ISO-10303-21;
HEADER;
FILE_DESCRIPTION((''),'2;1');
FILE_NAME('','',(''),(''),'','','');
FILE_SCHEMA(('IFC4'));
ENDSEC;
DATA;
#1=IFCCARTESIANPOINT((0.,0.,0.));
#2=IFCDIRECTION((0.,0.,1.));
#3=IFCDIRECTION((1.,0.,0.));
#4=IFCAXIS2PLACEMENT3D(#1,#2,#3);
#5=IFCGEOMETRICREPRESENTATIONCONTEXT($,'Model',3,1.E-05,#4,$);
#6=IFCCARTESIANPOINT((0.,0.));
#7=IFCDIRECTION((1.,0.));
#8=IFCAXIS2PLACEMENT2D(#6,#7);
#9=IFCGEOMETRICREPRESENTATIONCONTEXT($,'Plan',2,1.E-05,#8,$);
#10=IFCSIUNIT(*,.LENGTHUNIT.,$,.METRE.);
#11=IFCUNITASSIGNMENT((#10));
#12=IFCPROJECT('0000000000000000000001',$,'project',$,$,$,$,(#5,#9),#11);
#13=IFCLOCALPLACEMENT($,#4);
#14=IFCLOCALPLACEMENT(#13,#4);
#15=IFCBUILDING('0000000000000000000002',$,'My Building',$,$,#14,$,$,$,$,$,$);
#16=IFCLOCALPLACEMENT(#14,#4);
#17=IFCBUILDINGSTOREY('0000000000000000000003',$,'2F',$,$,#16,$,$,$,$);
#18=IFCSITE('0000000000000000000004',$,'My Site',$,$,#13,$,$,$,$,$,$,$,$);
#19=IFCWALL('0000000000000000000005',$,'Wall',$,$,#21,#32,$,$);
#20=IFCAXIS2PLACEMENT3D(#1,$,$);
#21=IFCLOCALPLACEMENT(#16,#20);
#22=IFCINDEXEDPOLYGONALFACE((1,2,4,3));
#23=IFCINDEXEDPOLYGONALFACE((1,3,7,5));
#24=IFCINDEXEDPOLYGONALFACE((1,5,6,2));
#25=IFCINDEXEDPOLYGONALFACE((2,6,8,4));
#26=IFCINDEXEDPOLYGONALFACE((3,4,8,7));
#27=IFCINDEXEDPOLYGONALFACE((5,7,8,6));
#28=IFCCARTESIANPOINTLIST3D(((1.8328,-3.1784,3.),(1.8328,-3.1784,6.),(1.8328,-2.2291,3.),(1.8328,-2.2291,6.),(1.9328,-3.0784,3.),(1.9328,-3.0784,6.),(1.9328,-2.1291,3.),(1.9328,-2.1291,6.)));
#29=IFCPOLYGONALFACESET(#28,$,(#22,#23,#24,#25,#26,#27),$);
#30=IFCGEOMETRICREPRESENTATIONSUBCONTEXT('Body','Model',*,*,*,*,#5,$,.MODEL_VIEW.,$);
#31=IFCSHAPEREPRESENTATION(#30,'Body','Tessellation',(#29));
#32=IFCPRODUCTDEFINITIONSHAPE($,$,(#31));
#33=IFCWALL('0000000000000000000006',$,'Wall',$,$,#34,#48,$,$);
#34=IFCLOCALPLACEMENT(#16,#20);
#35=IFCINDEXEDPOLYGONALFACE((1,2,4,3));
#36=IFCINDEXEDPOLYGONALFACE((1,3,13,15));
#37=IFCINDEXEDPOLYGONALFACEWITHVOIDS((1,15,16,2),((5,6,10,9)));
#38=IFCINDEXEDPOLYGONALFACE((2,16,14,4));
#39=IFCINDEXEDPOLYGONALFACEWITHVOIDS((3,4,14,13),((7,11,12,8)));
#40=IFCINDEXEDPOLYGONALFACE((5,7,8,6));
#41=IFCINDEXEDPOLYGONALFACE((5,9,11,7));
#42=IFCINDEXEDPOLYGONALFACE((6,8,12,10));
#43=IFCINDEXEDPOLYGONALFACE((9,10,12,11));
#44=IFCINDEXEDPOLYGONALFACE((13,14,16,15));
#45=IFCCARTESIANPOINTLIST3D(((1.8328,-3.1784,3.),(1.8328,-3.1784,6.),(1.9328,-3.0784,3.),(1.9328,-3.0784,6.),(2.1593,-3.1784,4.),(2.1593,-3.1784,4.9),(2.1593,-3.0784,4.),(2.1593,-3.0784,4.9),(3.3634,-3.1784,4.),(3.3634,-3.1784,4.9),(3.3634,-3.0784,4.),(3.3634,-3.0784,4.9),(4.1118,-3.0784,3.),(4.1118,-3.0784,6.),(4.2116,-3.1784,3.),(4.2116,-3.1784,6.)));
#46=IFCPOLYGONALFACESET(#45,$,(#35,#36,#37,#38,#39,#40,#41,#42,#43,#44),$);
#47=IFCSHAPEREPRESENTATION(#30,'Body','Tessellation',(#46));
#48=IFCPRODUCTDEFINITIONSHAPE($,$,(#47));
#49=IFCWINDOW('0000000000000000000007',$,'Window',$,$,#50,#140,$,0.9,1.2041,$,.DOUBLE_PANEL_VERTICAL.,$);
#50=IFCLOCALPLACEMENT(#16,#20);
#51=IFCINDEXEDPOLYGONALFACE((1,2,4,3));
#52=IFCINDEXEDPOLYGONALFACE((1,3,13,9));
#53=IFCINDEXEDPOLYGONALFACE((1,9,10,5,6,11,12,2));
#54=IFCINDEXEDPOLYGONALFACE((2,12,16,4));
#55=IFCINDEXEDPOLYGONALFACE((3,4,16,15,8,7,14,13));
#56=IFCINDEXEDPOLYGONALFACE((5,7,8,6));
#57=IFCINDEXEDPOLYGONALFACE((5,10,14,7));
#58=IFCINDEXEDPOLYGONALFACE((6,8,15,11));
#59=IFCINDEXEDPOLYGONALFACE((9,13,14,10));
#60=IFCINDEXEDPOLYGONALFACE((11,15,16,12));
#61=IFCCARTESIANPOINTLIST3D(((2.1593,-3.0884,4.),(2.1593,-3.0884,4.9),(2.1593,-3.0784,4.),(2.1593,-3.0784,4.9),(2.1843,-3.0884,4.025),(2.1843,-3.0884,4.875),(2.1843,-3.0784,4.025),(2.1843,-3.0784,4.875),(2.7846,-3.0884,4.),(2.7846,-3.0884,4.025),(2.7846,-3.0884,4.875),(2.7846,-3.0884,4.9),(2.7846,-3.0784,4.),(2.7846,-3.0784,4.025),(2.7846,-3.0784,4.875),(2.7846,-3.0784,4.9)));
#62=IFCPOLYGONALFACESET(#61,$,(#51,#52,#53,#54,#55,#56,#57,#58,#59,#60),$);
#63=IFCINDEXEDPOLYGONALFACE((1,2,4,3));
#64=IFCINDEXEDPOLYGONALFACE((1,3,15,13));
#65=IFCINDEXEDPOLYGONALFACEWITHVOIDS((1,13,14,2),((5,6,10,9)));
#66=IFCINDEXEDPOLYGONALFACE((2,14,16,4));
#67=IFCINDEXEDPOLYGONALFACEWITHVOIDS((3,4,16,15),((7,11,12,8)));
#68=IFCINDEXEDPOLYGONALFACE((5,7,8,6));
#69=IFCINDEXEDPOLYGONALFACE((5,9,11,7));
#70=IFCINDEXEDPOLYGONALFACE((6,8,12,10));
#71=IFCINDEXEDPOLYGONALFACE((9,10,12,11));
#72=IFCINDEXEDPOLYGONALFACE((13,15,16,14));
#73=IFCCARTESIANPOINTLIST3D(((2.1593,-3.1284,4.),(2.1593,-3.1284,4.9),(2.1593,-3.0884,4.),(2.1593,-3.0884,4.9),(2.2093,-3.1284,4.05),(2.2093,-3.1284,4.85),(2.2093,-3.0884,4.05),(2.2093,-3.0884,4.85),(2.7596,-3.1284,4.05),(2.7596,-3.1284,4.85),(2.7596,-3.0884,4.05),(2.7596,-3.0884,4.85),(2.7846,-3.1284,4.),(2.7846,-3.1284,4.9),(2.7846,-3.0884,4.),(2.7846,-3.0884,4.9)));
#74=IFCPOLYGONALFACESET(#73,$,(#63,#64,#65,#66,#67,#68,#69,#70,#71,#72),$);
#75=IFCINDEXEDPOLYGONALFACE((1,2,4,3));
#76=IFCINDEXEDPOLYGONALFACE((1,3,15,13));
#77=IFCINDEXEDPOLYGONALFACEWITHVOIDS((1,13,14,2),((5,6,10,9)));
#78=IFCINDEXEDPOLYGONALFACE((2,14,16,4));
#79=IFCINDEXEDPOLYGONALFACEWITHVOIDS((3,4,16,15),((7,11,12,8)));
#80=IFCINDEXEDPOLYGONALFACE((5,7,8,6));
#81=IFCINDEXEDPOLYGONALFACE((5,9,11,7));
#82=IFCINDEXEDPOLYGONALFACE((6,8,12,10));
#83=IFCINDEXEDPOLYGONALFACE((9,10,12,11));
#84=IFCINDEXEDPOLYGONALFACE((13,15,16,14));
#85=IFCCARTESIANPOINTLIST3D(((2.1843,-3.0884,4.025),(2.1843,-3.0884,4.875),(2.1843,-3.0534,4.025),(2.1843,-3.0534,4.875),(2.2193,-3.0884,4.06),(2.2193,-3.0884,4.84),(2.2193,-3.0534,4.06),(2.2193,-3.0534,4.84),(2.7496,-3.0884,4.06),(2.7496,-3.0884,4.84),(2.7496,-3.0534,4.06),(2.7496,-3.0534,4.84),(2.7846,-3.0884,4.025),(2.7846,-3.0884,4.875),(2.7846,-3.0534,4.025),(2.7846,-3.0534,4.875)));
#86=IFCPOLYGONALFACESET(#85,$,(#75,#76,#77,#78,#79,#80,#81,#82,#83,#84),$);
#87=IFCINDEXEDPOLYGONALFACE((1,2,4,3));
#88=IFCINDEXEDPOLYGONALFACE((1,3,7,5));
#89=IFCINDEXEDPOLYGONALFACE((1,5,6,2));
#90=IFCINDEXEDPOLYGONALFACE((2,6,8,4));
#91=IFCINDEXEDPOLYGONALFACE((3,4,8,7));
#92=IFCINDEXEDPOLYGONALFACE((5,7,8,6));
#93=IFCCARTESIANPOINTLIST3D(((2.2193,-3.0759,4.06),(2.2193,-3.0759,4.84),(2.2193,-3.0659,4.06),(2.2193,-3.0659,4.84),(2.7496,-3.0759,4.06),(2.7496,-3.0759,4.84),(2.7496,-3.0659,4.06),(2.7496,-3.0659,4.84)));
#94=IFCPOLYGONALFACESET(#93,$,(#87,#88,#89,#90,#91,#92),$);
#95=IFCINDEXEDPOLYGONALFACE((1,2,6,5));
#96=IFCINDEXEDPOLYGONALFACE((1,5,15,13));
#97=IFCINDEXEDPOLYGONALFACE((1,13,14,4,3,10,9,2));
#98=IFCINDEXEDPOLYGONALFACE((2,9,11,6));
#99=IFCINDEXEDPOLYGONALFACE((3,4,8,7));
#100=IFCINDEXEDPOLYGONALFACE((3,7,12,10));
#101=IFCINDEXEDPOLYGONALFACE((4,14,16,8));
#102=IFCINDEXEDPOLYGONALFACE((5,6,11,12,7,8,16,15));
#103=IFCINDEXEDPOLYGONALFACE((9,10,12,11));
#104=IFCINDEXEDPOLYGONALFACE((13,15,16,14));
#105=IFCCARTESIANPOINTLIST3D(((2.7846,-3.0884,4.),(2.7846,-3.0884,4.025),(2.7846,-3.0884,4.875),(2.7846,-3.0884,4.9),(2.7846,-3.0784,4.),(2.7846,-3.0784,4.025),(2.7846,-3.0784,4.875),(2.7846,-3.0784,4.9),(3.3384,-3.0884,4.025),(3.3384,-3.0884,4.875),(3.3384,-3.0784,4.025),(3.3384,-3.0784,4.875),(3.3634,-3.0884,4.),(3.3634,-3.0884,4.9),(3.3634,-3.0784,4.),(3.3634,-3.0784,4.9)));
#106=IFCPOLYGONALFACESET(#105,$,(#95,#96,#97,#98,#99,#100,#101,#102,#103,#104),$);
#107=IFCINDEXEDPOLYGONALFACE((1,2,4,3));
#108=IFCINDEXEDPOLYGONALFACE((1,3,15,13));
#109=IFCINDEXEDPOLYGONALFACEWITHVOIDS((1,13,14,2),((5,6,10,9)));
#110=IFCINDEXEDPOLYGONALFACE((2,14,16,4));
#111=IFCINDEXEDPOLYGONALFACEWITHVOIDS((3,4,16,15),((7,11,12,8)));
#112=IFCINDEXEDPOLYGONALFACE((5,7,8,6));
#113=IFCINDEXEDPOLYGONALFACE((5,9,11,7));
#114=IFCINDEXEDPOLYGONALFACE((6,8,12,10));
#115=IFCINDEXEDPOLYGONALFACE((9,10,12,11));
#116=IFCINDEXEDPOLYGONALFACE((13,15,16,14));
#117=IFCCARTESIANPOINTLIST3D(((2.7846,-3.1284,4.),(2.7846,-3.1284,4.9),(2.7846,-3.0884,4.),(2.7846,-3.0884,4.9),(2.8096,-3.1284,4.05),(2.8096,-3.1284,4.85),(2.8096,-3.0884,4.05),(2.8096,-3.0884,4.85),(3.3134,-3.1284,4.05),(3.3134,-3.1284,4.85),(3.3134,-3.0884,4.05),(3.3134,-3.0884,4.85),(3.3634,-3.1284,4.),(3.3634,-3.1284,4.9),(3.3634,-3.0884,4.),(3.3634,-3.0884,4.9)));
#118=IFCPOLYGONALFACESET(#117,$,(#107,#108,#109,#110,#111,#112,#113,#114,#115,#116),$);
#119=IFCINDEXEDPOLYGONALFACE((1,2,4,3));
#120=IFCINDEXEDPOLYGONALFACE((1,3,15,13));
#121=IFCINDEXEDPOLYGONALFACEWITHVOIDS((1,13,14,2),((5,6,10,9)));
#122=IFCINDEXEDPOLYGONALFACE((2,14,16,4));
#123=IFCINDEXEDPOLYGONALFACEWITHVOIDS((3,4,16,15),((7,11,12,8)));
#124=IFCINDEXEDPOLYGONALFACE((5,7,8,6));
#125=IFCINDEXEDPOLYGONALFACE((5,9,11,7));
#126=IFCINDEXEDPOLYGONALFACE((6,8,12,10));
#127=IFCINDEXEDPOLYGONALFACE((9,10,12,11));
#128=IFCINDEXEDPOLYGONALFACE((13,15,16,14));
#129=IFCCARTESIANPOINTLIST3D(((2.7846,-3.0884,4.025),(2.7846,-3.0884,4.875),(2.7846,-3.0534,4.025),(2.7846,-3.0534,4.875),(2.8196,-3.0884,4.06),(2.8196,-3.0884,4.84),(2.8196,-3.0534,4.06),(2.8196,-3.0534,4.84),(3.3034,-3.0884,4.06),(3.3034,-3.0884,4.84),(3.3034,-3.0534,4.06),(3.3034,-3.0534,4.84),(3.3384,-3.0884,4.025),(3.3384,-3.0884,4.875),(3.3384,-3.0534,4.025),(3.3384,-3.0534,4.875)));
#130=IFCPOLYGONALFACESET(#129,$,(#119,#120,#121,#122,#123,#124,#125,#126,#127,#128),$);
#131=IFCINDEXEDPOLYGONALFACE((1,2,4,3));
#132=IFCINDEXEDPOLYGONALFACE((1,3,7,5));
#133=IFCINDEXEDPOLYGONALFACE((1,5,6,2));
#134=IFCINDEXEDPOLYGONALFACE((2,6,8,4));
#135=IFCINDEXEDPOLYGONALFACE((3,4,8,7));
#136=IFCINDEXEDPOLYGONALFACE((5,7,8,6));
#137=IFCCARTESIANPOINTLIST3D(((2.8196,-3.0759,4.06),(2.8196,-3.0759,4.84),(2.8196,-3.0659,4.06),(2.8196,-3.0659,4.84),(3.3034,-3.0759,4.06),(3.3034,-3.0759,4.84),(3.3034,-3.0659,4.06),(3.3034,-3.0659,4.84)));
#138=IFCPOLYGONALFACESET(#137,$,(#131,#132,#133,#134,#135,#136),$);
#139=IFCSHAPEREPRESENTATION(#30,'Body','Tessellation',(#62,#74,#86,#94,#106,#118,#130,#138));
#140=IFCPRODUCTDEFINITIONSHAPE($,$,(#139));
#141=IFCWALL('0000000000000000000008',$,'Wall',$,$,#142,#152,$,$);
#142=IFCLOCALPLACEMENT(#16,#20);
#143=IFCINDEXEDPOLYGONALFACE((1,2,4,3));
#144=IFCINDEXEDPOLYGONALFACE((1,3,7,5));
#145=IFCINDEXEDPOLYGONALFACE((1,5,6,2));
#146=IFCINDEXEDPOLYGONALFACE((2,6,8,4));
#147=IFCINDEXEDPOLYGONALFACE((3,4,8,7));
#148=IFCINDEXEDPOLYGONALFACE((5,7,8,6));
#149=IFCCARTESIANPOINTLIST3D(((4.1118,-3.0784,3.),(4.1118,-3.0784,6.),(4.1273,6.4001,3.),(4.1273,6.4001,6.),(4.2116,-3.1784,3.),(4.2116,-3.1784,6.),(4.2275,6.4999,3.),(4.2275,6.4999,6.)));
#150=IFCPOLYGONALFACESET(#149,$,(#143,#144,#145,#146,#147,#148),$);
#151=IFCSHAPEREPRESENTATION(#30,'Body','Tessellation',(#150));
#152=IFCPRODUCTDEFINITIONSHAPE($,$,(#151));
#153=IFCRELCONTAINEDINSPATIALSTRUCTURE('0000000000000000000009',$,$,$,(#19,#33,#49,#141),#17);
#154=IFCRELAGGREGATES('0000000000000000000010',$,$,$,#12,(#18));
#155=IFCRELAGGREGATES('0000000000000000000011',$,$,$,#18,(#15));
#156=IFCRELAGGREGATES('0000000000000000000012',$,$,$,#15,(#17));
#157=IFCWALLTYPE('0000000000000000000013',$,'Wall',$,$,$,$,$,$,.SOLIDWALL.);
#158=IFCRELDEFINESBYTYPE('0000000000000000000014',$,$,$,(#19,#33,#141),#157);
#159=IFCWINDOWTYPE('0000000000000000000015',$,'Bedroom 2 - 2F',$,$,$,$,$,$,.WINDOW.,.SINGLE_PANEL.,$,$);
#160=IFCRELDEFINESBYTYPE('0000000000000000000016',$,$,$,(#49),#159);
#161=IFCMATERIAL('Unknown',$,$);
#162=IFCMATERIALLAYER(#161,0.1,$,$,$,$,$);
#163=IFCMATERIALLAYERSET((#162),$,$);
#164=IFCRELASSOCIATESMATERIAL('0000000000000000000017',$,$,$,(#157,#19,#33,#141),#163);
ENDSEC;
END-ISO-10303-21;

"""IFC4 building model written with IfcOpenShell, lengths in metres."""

from ifc_helpers import new_model, entity, si_unit, frame, origin_with_axes, origin_2d_with_axis, place, context, subcontext, project, spatial, line, indexed_curve, outline, extrude, shape, source, transform, mapped, material, layer, layer_set, layer_usage, type_object, type_shapes, element, fill, save


model = new_model("IFC4")

# Units and contexts
model_context = context("Model", 3, precision=1e-05, world=origin_with_axes())
plan_context = context("Plan", 2, precision=1e-05, world=origin_2d_with_axis())
body_context_1 = subcontext(model_context, "Body", "Model", "MODEL_VIEW")
body_context_2 = subcontext(plan_context, "Body", "Plan", "PLAN_VIEW")
ifc_project = project(units=[si_unit("LENGTHUNIT", "METRE")], contexts=[model_context, plan_context])

# Site, building, storey
site_placement = place(None, origin_with_axes())
site = spatial("IfcSite", under=ifc_project, at=site_placement, Name="My Site")
building_placement = place(site_placement, origin_with_axes())
building = spatial("IfcBuilding", under=site, at=building_placement, Name="My Building")
storey_placement = place(building_placement, origin_with_axes())
storey = spatial("IfcBuildingStorey", under=building, at=storey_placement, Name="2F")

# Wall
ifc_material = material(Name="Unknown")
ifc_layer = layer(ifc_material, 0.1)
ifc_layer_set = layer_set([ifc_layer])
ifc_layer_usage_1 = layer_usage(ifc_layer_set, "AXIS2", "POSITIVE", 0.0)
wall_type = type_object("IfcWallType", Name="Wall", PredefinedType="SOLIDWALL", material=ifc_layer_set)
wall_1_placement = place(storey_placement, frame((1.8328, -2.2291, 3.0), z_axis=(0.0, 0.0, 1.0), x_axis=(0.0, -1.0, 0.0)))
element("IfcWall", 1, at=wall_1_placement, inside=storey, type_object=wall_type, material=ifc_layer_usage_1, Name="Wall", context=body_context_1, shape_type="SweptSolid", body=[
    extrude(outline(indexed_curve([(0.0, 0.0), (-0.1, 0.1), (0.8493, 0.1), (0.9493, 0.0)], segments=[line(1, 2, 3, 4, 1)])), origin_with_axes(), (0.0, 0.0, 1.0), 3.0),
])

# Wall, opening, window
ifc_layer_usage_2 = layer_usage(ifc_layer_set, "AXIS2", "POSITIVE", 0.0)
wall_2_placement = place(storey_placement, frame((1.8328, -3.1784, 3.0), z_axis=(0.0, 0.0, 1.0), x_axis=(1.0, 0.0, 0.0)))
wall_2 = element("IfcWall", 2, at=wall_2_placement, inside=storey, type_object=wall_type, material=ifc_layer_usage_2, Name="Wall", context=body_context_1, shape_type="SweptSolid", body=[
    extrude(outline(indexed_curve([(0.0, 0.0), (0.1, 0.1), (2.279, 0.1), (2.3789, 0.0)], segments=[line(1, 2, 3, 4, 1)])), origin_with_axes(), (0.0, 0.0, 1.0), 3.0),
])
shared_shape_1 = source(origin_with_axes(), body_context_1, "Body", "SweptSolid", [
    extrude(outline(indexed_curve([(0.0, 0.0), (1.2041, 0.0), (1.2041, 0.9), (0.0, 0.9)], segments=[line(1, 2, 3, 4, 1)])), frame((0.0, -0.6, 0.0), z_axis=(0.0, -1.0, 0.0), x_axis=(1.0, 0.0, 0.0)), (0.0, 0.0, -1.0), 1.2),
])
opening_1_placement = place(wall_2_placement, frame((0.3266, 0.0, 1.0), z_axis=(0.0, 0.0, 1.0), x_axis=(1.0, 0.0, 0.0)))
opening_1 = element("IfcOpeningElement", 3, at=opening_1_placement, cuts=wall_2, PredefinedType="OPENING", context=body_context_1, shape_type="MappedRepresentation", body=[
    mapped(shared_shape_1, transform((0.0, 0.0, 0.0), x_axis=(1.0, 0.0, 0.0), y_axis=(0.0, 1.0, 0.0), z_axis=(0.0, 0.0, 1.0), scale=1.0)),
])
window_type_1 = type_object("IfcWindowType", Name="Bedroom 2 - 2F", PartitioningType="SINGLE_PANEL", PredefinedType="WINDOW")
shared_shape_2 = source(origin_with_axes(), body_context_1, "Body", "SweptSolid", [
    extrude(outline(indexed_curve([(0.6253, 0.0), (0.0, 0.0), (0.0, 0.9), (0.6253, 0.9), (0.6253, 0.875), (0.025, 0.875), (0.025, 0.025), (0.6253, 0.025)], segments=[line(1, 2, 3, 4, 5, 6, 7, 8, 1)])), frame((0.0, 0.09, 0.0), z_axis=(0.0, -1.0, 0.0), x_axis=(1.0, 0.0, 0.0)), (0.0, 0.0, -1.0), 0.01),
    extrude(outline(indexed_curve([(0.0, 0.0), (0.6253, 0.0), (0.6253, 0.9), (0.0, 0.9)], segments=[line(1, 2, 3, 4, 1)]), holes=[indexed_curve([(0.05, 0.05), (0.6003, 0.05), (0.6003, 0.85), (0.05, 0.85)], segments=[line(1, 2, 3, 4, 1)])]), frame((0.0, 0.05, 0.0), z_axis=(0.0, -1.0, 0.0), x_axis=(1.0, 0.0, 0.0)), (0.0, 0.0, -1.0), 0.04),
    extrude(outline(indexed_curve([(0.0, 0.0), (0.6003, 0.0), (0.6003, 0.85), (0.0, 0.85)], segments=[line(1, 2, 3, 4, 1)]), holes=[indexed_curve([(0.035, 0.035), (0.5653, 0.035), (0.5653, 0.815), (0.035, 0.815)], segments=[line(1, 2, 3, 4, 1)])]), frame((0.025, 0.09, 0.025), z_axis=(0.0, -1.0, 0.0), x_axis=(1.0, 0.0, 0.0)), (0.0, 0.0, -1.0), 0.035),
    extrude(outline(indexed_curve([(0.035, 0.035), (0.5653, 0.035), (0.5653, 0.815), (0.035, 0.815)], segments=[line(1, 2, 3, 4, 1)])), frame((0.025, 0.1025, 0.025), z_axis=(0.0, -1.0, 0.0), x_axis=(1.0, 0.0, 0.0)), (0.0, 0.0, -1.0), 0.01),
    extrude(outline(indexed_curve([(0.0, 0.9), (0.5788, 0.9), (0.5788, 0.0), (0.0, 0.0), (0.0, 0.025), (0.5538, 0.025), (0.5538, 0.875), (0.0, 0.875)], segments=[line(1, 2, 3, 4, 5, 6, 7, 8, 1)])), frame((0.6253, 0.09, 0.0), z_axis=(0.0, -1.0, 0.0), x_axis=(1.0, 0.0, 0.0)), (0.0, 0.0, -1.0), 0.01),
    extrude(outline(indexed_curve([(0.0, 0.0), (0.5788, 0.0), (0.5788, 0.9), (0.0, 0.9)], segments=[line(1, 2, 3, 4, 1)]), holes=[indexed_curve([(0.025, 0.05), (0.5288, 0.05), (0.5288, 0.85), (0.025, 0.85)], segments=[line(1, 2, 3, 4, 1)])]), frame((0.6253, 0.05, 0.0), z_axis=(0.0, -1.0, 0.0), x_axis=(1.0, 0.0, 0.0)), (0.0, 0.0, -1.0), 0.04),
    extrude(outline(indexed_curve([(0.0, 0.0), (0.5538, 0.0), (0.5538, 0.85), (0.0, 0.85)], segments=[line(1, 2, 3, 4, 1)]), holes=[indexed_curve([(0.035, 0.035), (0.5188, 0.035), (0.5188, 0.815), (0.035, 0.815)], segments=[line(1, 2, 3, 4, 1)])]), frame((0.6253, 0.09, 0.025), z_axis=(0.0, -1.0, 0.0), x_axis=(1.0, 0.0, 0.0)), (0.0, 0.0, -1.0), 0.035),
    extrude(outline(indexed_curve([(0.035, 0.035), (0.5188, 0.035), (0.5188, 0.815), (0.035, 0.815)], segments=[line(1, 2, 3, 4, 1)])), frame((0.6253, 0.1025, 0.025), z_axis=(0.0, -1.0, 0.0), x_axis=(1.0, 0.0, 0.0)), (0.0, 0.0, -1.0), 0.01),
])
shared_shape_3 = source(origin_with_axes(), body_context_2, "Body", "Curve2D", [
    entity("IfcIndexedPolyCurve", entity("IfcCartesianPointList2D", [[0.05, 0.05], [0.6003, 0.05]])),
    entity("IfcIndexedPolyCurve", entity("IfcCartesianPointList2D", [[0.0, 0.1], [0.025, 0.1], [0.025, 0.09], [0.05, 0.09], [0.05, 0.05], [0.0, 0.05]]), [entity("IfcLineIndex", [1, 2, 3, 4, 5, 6, 1])]),
    entity("IfcIndexedPolyCurve", entity("IfcCartesianPointList2D", [[0.6253, 0.1], [0.6253, 0.1], [0.6253, 0.09], [0.6003, 0.09], [0.6003, 0.05], [0.6253, 0.05]])),
    entity("IfcIndexedPolyCurve", entity("IfcCartesianPointList2D", [[0.025, 0.09], [0.06, 0.09], [0.06, 0.125], [0.025, 0.125]]), [entity("IfcLineIndex", [1, 2, 3, 4, 1])]),
    entity("IfcIndexedPolyCurve", entity("IfcCartesianPointList2D", [[0.6253, 0.09], [0.5903, 0.09], [0.5903, 0.125], [0.6253, 0.125]]), [entity("IfcLineIndex", [1, 2, 3, 4, 1])]),
    entity("IfcIndexedPolyCurve", entity("IfcCartesianPointList2D", [[0.06, 0.09], [0.5903, 0.09]])),
    entity("IfcIndexedPolyCurve", entity("IfcCartesianPointList2D", [[0.06, 0.125], [0.5903, 0.125]])),
    entity("IfcIndexedPolyCurve", entity("IfcCartesianPointList2D", [[0.06, 0.1075], [0.5903, 0.1075]])),
    entity("IfcIndexedPolyCurve", entity("IfcCartesianPointList2D", [[0.6503, 0.05], [1.1541, 0.05]])),
    entity("IfcIndexedPolyCurve", entity("IfcCartesianPointList2D", [[0.6253, 0.1], [0.6253, 0.1], [0.6253, 0.09], [0.6503, 0.09], [0.6503, 0.05], [0.6253, 0.05]])),
    entity("IfcIndexedPolyCurve", entity("IfcCartesianPointList2D", [[1.2041, 0.1], [1.1791, 0.1], [1.1791, 0.09], [1.1541, 0.09], [1.1541, 0.05], [1.2041, 0.05]]), [entity("IfcLineIndex", [1, 2, 3, 4, 5, 6, 1])]),
    entity("IfcIndexedPolyCurve", entity("IfcCartesianPointList2D", [[0.6253, 0.09], [0.6603, 0.09], [0.6603, 0.125], [0.6253, 0.125]]), [entity("IfcLineIndex", [1, 2, 3, 4, 1])]),
    entity("IfcIndexedPolyCurve", entity("IfcCartesianPointList2D", [[1.1791, 0.09], [1.1441, 0.09], [1.1441, 0.125], [1.1791, 0.125]]), [entity("IfcLineIndex", [1, 2, 3, 4, 1])]),
    entity("IfcIndexedPolyCurve", entity("IfcCartesianPointList2D", [[0.6603, 0.09], [1.1441, 0.09]])),
    entity("IfcIndexedPolyCurve", entity("IfcCartesianPointList2D", [[0.6603, 0.125], [1.1441, 0.125]])),
    entity("IfcIndexedPolyCurve", entity("IfcCartesianPointList2D", [[0.6603, 0.1075], [1.1441, 0.1075]])),
])
type_shapes(window_type_1, [shared_shape_2, shared_shape_3])
window_1_placement = place(opening_1_placement, origin_with_axes())
window_1 = element("IfcWindow", 4, at=window_1_placement, inside=storey, type_object=window_type_1, Name="Window", OverallHeight=0.9, OverallWidth=1.2041, PartitioningType="DOUBLE_PANEL_VERTICAL", shapes=[
    shape(body_context_1, "Body", "MappedRepresentation", [mapped(shared_shape_2, transform((0.0, 0.0, 0.0), x_axis=(1.0, 0.0, 0.0), y_axis=(0.0, 1.0, 0.0), z_axis=(0.0, 0.0, 1.0), scale=1.0))]),
    shape(body_context_2, "Body", "MappedRepresentation", [mapped(shared_shape_3, transform((0.0, 0.0, 0.0), x_axis=(1.0, 0.0, 0.0), y_axis=(0.0, 1.0, 0.0), z_axis=(0.0, 0.0, 1.0), scale=1.0))]),
])
fill(opening_1, window_1)

# Wall
ifc_layer_usage_3 = layer_usage(ifc_layer_set, "AXIS2", "POSITIVE", 0.0)
wall_3_placement = place(storey_placement, frame((4.2116, -3.1784, 3.0), z_axis=(0.0, 0.0, 1.0), x_axis=(0.001639, 0.999999, 0.0)))
element("IfcWall", 5, at=wall_3_placement, inside=storey, type_object=wall_type, material=ifc_layer_usage_3, Name="Wall", context=body_context_1, shape_type="SweptSolid", body=[
    extrude(outline(indexed_curve([(0.0, 0.0), (0.0998, 0.1), (9.5783, 0.1), (9.6783, 0.0)], segments=[line(1, 2, 3, 4, 1)])), origin_with_axes(), (0.0, 0.0, 1.0), 3.0),
])

save(model, "model.ifc")
